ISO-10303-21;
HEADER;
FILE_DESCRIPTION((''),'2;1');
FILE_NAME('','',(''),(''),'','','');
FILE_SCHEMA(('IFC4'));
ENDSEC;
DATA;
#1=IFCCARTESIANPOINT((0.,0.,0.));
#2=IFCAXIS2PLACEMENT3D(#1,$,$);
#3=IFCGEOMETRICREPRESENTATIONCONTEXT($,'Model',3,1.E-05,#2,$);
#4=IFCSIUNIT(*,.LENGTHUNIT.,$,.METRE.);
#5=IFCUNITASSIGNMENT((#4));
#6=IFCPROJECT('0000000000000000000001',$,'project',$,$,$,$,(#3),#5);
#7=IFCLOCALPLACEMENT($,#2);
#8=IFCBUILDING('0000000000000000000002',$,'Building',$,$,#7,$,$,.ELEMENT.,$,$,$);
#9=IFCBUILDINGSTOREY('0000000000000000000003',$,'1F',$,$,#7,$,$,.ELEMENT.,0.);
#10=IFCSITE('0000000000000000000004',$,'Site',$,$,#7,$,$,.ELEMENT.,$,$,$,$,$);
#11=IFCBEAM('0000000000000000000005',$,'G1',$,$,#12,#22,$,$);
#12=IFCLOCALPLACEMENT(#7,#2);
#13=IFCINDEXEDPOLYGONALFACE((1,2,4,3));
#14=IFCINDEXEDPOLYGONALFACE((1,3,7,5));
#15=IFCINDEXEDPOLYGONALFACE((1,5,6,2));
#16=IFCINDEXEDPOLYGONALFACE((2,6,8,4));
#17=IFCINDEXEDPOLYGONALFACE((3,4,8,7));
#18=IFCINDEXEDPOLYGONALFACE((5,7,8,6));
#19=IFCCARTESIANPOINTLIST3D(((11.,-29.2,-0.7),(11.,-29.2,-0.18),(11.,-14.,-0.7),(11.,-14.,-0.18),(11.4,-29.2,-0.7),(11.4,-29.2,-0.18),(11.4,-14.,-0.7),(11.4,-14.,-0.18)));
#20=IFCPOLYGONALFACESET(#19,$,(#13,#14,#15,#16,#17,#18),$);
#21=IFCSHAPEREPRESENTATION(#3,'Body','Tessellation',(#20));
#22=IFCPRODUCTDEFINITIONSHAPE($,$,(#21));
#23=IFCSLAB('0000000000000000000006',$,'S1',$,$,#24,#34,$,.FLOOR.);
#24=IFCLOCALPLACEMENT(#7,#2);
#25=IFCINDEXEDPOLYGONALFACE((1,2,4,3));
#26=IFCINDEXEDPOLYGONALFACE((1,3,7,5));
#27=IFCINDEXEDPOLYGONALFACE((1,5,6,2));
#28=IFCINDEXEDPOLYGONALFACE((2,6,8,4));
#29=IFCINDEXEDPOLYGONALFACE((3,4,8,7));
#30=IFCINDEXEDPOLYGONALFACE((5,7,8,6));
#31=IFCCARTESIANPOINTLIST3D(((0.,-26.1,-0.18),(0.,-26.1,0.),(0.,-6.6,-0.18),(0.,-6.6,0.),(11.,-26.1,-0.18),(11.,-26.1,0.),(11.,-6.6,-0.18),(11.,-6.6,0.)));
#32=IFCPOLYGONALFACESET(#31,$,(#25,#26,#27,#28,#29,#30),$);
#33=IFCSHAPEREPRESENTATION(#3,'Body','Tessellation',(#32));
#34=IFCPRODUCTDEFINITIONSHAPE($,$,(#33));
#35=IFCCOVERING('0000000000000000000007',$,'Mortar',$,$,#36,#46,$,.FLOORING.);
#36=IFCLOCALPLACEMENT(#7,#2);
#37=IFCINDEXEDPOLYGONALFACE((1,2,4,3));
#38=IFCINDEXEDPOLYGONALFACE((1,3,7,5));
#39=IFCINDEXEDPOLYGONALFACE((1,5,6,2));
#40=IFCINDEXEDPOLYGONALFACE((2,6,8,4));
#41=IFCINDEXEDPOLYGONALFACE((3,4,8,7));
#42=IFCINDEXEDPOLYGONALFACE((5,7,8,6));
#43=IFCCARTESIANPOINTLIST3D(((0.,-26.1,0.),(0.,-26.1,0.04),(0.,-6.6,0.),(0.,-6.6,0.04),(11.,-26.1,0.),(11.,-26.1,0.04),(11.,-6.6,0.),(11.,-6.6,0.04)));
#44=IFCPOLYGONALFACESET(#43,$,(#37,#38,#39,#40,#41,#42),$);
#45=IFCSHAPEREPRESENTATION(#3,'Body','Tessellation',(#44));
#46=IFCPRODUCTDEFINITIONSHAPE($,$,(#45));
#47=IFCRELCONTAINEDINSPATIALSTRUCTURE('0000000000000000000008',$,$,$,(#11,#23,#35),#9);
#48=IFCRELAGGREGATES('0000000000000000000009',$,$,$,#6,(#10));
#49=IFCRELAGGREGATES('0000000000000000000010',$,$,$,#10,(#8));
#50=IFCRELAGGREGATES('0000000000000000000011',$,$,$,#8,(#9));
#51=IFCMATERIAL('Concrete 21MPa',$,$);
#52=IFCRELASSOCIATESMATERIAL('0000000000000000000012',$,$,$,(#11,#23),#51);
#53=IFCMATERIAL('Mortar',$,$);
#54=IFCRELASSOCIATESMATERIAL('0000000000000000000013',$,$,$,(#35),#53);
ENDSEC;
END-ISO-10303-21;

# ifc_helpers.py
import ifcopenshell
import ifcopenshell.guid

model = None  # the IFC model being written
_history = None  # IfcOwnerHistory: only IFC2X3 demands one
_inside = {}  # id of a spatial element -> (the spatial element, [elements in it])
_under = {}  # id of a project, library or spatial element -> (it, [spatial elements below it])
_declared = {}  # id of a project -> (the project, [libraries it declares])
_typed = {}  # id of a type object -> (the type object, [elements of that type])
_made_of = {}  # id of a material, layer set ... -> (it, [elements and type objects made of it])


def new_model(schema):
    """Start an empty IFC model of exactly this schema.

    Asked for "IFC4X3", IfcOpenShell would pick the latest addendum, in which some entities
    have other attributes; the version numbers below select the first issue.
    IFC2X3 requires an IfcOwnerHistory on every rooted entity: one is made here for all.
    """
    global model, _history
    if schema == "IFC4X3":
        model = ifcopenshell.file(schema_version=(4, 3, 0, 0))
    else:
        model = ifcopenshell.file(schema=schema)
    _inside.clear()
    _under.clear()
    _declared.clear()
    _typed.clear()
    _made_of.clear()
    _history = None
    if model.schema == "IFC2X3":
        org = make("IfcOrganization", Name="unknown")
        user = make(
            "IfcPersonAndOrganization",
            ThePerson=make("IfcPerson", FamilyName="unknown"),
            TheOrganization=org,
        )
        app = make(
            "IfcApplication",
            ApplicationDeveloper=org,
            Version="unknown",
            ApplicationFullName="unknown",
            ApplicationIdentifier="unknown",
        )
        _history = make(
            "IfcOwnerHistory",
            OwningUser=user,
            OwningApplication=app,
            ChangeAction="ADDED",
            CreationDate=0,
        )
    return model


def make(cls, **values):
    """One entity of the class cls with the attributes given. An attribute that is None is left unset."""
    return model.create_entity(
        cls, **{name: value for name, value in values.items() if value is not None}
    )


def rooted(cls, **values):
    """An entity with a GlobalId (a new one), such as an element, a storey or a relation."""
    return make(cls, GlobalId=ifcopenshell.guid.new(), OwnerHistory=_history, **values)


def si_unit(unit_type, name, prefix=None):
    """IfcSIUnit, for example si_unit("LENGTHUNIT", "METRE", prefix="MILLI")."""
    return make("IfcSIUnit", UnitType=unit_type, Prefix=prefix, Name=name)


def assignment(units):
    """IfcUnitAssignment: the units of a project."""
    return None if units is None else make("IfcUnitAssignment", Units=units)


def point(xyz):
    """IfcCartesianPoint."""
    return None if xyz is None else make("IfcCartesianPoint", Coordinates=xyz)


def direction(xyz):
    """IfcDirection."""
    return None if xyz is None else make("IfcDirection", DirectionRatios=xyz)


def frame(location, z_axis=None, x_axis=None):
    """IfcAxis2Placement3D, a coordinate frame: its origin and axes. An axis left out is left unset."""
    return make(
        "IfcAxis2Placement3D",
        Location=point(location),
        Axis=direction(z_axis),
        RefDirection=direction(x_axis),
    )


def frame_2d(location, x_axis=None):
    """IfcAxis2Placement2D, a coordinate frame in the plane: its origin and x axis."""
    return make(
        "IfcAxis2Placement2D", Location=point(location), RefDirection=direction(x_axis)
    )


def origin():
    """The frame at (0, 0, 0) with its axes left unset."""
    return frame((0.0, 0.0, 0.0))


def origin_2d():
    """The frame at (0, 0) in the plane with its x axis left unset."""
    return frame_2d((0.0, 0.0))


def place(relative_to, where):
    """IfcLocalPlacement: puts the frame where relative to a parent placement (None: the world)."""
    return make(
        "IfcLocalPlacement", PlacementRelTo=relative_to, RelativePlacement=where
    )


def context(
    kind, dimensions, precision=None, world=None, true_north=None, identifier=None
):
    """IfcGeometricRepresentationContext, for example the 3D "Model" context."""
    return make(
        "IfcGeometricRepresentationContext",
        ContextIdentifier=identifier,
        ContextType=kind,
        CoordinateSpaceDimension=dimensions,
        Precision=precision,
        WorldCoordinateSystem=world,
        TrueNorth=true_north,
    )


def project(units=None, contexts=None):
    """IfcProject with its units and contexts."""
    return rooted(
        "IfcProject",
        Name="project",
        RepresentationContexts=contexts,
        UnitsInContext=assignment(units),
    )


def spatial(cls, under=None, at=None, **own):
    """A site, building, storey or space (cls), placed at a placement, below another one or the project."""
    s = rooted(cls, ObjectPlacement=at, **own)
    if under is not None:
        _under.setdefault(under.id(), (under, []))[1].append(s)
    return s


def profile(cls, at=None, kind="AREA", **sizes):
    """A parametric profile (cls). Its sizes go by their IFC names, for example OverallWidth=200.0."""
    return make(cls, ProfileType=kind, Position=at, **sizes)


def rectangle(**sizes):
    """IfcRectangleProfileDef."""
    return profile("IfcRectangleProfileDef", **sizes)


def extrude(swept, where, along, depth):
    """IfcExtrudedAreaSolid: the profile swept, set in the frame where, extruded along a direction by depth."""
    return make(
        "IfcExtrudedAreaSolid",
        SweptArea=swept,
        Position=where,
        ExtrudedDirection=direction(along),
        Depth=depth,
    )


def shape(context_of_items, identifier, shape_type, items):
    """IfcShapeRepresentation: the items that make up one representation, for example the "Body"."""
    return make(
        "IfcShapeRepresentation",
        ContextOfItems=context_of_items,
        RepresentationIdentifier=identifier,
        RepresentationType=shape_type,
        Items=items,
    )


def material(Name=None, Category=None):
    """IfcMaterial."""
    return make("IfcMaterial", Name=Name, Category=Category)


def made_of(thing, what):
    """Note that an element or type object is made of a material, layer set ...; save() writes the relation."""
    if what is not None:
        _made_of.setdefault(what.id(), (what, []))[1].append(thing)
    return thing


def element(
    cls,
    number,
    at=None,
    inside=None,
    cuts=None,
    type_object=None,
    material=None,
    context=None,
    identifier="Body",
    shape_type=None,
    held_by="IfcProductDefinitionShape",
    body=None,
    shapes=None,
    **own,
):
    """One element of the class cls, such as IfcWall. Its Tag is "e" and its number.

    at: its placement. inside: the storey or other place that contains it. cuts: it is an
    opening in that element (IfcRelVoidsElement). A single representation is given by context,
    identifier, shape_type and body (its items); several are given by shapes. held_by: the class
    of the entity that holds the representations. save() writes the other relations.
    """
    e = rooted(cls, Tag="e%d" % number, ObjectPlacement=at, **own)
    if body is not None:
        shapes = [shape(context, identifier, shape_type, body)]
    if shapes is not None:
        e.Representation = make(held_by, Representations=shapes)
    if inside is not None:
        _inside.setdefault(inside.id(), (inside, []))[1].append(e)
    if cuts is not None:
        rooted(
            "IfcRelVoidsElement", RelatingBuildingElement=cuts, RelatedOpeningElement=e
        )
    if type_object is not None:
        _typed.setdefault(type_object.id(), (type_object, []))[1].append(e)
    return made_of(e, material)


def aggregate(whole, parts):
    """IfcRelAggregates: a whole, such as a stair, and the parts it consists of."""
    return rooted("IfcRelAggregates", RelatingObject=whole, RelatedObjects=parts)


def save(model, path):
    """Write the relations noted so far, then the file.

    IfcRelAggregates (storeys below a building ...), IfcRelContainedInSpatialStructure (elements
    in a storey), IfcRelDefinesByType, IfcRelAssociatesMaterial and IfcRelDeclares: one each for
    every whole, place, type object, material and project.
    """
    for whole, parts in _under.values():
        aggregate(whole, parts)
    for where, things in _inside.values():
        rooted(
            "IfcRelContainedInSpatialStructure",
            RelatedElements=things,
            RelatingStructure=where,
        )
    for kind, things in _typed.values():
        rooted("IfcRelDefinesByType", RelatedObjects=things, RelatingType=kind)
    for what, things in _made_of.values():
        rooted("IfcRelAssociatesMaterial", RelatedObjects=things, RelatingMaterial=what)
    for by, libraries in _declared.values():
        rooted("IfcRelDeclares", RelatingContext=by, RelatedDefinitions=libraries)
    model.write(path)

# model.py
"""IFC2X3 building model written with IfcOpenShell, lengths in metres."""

from ifc_helpers import new_model, si_unit, frame, origin, origin_2d, place, context, project, spatial, rectangle, extrude, material, element, save


model = new_model("IFC2X3")

# Units and contexts
model_context = context("Model", 3, precision=1e-05, world=origin())
ifc_project = project(units=[si_unit("LENGTHUNIT", "METRE")], contexts=[model_context])

# Site, building, storey
placement = place(None, origin())
site = spatial("IfcSite", under=ifc_project, at=placement, Name="Site", CompositionType="ELEMENT")
building = spatial("IfcBuilding", under=site, at=placement, Name="Building", CompositionType="ELEMENT")
storey = spatial("IfcBuildingStorey", under=building, at=placement, Name="1F", CompositionType="ELEMENT", Elevation=0.0)

# Shared definitions
ifc_material_1 = material(Name="Concrete 21MPa")

# Beam
beam_placement = place(None, frame((11.2, -21.6, -0.7)))
element("IfcBeam", 1, at=beam_placement, inside=storey, material=ifc_material_1, Name="G1", context=model_context, shape_type="SweptSolid", body=[
    extrude(rectangle(XDim=0.4, YDim=15.2, at=origin_2d()), origin(), (0.0, 0.0, 1.0), 0.52),
])

# Slab
slab_placement = place(None, frame((5.5, -16.35, -0.18)))
element("IfcSlab", 2, at=slab_placement, inside=storey, material=ifc_material_1, Name="S1", PredefinedType="FLOOR", context=model_context, shape_type="SweptSolid", body=[
    extrude(rectangle(XDim=11.0, YDim=19.5, at=origin_2d()), origin(), (0.0, 0.0, 1.0), 0.18),
])

# Covering
ifc_material_2 = material(Name="Mortar")
covering_placement = place(None, frame((5.5, -16.35, 0.0)))
element("IfcCovering", 3, at=covering_placement, inside=storey, material=ifc_material_2, Name="Mortar", PredefinedType="FLOORING", context=model_context, shape_type="SweptSolid", body=[
    extrude(rectangle(XDim=11.0, YDim=19.5, at=origin_2d()), origin(), (0.0, 0.0, 1.0), 0.04),
])

save(model, "model.ifc")
